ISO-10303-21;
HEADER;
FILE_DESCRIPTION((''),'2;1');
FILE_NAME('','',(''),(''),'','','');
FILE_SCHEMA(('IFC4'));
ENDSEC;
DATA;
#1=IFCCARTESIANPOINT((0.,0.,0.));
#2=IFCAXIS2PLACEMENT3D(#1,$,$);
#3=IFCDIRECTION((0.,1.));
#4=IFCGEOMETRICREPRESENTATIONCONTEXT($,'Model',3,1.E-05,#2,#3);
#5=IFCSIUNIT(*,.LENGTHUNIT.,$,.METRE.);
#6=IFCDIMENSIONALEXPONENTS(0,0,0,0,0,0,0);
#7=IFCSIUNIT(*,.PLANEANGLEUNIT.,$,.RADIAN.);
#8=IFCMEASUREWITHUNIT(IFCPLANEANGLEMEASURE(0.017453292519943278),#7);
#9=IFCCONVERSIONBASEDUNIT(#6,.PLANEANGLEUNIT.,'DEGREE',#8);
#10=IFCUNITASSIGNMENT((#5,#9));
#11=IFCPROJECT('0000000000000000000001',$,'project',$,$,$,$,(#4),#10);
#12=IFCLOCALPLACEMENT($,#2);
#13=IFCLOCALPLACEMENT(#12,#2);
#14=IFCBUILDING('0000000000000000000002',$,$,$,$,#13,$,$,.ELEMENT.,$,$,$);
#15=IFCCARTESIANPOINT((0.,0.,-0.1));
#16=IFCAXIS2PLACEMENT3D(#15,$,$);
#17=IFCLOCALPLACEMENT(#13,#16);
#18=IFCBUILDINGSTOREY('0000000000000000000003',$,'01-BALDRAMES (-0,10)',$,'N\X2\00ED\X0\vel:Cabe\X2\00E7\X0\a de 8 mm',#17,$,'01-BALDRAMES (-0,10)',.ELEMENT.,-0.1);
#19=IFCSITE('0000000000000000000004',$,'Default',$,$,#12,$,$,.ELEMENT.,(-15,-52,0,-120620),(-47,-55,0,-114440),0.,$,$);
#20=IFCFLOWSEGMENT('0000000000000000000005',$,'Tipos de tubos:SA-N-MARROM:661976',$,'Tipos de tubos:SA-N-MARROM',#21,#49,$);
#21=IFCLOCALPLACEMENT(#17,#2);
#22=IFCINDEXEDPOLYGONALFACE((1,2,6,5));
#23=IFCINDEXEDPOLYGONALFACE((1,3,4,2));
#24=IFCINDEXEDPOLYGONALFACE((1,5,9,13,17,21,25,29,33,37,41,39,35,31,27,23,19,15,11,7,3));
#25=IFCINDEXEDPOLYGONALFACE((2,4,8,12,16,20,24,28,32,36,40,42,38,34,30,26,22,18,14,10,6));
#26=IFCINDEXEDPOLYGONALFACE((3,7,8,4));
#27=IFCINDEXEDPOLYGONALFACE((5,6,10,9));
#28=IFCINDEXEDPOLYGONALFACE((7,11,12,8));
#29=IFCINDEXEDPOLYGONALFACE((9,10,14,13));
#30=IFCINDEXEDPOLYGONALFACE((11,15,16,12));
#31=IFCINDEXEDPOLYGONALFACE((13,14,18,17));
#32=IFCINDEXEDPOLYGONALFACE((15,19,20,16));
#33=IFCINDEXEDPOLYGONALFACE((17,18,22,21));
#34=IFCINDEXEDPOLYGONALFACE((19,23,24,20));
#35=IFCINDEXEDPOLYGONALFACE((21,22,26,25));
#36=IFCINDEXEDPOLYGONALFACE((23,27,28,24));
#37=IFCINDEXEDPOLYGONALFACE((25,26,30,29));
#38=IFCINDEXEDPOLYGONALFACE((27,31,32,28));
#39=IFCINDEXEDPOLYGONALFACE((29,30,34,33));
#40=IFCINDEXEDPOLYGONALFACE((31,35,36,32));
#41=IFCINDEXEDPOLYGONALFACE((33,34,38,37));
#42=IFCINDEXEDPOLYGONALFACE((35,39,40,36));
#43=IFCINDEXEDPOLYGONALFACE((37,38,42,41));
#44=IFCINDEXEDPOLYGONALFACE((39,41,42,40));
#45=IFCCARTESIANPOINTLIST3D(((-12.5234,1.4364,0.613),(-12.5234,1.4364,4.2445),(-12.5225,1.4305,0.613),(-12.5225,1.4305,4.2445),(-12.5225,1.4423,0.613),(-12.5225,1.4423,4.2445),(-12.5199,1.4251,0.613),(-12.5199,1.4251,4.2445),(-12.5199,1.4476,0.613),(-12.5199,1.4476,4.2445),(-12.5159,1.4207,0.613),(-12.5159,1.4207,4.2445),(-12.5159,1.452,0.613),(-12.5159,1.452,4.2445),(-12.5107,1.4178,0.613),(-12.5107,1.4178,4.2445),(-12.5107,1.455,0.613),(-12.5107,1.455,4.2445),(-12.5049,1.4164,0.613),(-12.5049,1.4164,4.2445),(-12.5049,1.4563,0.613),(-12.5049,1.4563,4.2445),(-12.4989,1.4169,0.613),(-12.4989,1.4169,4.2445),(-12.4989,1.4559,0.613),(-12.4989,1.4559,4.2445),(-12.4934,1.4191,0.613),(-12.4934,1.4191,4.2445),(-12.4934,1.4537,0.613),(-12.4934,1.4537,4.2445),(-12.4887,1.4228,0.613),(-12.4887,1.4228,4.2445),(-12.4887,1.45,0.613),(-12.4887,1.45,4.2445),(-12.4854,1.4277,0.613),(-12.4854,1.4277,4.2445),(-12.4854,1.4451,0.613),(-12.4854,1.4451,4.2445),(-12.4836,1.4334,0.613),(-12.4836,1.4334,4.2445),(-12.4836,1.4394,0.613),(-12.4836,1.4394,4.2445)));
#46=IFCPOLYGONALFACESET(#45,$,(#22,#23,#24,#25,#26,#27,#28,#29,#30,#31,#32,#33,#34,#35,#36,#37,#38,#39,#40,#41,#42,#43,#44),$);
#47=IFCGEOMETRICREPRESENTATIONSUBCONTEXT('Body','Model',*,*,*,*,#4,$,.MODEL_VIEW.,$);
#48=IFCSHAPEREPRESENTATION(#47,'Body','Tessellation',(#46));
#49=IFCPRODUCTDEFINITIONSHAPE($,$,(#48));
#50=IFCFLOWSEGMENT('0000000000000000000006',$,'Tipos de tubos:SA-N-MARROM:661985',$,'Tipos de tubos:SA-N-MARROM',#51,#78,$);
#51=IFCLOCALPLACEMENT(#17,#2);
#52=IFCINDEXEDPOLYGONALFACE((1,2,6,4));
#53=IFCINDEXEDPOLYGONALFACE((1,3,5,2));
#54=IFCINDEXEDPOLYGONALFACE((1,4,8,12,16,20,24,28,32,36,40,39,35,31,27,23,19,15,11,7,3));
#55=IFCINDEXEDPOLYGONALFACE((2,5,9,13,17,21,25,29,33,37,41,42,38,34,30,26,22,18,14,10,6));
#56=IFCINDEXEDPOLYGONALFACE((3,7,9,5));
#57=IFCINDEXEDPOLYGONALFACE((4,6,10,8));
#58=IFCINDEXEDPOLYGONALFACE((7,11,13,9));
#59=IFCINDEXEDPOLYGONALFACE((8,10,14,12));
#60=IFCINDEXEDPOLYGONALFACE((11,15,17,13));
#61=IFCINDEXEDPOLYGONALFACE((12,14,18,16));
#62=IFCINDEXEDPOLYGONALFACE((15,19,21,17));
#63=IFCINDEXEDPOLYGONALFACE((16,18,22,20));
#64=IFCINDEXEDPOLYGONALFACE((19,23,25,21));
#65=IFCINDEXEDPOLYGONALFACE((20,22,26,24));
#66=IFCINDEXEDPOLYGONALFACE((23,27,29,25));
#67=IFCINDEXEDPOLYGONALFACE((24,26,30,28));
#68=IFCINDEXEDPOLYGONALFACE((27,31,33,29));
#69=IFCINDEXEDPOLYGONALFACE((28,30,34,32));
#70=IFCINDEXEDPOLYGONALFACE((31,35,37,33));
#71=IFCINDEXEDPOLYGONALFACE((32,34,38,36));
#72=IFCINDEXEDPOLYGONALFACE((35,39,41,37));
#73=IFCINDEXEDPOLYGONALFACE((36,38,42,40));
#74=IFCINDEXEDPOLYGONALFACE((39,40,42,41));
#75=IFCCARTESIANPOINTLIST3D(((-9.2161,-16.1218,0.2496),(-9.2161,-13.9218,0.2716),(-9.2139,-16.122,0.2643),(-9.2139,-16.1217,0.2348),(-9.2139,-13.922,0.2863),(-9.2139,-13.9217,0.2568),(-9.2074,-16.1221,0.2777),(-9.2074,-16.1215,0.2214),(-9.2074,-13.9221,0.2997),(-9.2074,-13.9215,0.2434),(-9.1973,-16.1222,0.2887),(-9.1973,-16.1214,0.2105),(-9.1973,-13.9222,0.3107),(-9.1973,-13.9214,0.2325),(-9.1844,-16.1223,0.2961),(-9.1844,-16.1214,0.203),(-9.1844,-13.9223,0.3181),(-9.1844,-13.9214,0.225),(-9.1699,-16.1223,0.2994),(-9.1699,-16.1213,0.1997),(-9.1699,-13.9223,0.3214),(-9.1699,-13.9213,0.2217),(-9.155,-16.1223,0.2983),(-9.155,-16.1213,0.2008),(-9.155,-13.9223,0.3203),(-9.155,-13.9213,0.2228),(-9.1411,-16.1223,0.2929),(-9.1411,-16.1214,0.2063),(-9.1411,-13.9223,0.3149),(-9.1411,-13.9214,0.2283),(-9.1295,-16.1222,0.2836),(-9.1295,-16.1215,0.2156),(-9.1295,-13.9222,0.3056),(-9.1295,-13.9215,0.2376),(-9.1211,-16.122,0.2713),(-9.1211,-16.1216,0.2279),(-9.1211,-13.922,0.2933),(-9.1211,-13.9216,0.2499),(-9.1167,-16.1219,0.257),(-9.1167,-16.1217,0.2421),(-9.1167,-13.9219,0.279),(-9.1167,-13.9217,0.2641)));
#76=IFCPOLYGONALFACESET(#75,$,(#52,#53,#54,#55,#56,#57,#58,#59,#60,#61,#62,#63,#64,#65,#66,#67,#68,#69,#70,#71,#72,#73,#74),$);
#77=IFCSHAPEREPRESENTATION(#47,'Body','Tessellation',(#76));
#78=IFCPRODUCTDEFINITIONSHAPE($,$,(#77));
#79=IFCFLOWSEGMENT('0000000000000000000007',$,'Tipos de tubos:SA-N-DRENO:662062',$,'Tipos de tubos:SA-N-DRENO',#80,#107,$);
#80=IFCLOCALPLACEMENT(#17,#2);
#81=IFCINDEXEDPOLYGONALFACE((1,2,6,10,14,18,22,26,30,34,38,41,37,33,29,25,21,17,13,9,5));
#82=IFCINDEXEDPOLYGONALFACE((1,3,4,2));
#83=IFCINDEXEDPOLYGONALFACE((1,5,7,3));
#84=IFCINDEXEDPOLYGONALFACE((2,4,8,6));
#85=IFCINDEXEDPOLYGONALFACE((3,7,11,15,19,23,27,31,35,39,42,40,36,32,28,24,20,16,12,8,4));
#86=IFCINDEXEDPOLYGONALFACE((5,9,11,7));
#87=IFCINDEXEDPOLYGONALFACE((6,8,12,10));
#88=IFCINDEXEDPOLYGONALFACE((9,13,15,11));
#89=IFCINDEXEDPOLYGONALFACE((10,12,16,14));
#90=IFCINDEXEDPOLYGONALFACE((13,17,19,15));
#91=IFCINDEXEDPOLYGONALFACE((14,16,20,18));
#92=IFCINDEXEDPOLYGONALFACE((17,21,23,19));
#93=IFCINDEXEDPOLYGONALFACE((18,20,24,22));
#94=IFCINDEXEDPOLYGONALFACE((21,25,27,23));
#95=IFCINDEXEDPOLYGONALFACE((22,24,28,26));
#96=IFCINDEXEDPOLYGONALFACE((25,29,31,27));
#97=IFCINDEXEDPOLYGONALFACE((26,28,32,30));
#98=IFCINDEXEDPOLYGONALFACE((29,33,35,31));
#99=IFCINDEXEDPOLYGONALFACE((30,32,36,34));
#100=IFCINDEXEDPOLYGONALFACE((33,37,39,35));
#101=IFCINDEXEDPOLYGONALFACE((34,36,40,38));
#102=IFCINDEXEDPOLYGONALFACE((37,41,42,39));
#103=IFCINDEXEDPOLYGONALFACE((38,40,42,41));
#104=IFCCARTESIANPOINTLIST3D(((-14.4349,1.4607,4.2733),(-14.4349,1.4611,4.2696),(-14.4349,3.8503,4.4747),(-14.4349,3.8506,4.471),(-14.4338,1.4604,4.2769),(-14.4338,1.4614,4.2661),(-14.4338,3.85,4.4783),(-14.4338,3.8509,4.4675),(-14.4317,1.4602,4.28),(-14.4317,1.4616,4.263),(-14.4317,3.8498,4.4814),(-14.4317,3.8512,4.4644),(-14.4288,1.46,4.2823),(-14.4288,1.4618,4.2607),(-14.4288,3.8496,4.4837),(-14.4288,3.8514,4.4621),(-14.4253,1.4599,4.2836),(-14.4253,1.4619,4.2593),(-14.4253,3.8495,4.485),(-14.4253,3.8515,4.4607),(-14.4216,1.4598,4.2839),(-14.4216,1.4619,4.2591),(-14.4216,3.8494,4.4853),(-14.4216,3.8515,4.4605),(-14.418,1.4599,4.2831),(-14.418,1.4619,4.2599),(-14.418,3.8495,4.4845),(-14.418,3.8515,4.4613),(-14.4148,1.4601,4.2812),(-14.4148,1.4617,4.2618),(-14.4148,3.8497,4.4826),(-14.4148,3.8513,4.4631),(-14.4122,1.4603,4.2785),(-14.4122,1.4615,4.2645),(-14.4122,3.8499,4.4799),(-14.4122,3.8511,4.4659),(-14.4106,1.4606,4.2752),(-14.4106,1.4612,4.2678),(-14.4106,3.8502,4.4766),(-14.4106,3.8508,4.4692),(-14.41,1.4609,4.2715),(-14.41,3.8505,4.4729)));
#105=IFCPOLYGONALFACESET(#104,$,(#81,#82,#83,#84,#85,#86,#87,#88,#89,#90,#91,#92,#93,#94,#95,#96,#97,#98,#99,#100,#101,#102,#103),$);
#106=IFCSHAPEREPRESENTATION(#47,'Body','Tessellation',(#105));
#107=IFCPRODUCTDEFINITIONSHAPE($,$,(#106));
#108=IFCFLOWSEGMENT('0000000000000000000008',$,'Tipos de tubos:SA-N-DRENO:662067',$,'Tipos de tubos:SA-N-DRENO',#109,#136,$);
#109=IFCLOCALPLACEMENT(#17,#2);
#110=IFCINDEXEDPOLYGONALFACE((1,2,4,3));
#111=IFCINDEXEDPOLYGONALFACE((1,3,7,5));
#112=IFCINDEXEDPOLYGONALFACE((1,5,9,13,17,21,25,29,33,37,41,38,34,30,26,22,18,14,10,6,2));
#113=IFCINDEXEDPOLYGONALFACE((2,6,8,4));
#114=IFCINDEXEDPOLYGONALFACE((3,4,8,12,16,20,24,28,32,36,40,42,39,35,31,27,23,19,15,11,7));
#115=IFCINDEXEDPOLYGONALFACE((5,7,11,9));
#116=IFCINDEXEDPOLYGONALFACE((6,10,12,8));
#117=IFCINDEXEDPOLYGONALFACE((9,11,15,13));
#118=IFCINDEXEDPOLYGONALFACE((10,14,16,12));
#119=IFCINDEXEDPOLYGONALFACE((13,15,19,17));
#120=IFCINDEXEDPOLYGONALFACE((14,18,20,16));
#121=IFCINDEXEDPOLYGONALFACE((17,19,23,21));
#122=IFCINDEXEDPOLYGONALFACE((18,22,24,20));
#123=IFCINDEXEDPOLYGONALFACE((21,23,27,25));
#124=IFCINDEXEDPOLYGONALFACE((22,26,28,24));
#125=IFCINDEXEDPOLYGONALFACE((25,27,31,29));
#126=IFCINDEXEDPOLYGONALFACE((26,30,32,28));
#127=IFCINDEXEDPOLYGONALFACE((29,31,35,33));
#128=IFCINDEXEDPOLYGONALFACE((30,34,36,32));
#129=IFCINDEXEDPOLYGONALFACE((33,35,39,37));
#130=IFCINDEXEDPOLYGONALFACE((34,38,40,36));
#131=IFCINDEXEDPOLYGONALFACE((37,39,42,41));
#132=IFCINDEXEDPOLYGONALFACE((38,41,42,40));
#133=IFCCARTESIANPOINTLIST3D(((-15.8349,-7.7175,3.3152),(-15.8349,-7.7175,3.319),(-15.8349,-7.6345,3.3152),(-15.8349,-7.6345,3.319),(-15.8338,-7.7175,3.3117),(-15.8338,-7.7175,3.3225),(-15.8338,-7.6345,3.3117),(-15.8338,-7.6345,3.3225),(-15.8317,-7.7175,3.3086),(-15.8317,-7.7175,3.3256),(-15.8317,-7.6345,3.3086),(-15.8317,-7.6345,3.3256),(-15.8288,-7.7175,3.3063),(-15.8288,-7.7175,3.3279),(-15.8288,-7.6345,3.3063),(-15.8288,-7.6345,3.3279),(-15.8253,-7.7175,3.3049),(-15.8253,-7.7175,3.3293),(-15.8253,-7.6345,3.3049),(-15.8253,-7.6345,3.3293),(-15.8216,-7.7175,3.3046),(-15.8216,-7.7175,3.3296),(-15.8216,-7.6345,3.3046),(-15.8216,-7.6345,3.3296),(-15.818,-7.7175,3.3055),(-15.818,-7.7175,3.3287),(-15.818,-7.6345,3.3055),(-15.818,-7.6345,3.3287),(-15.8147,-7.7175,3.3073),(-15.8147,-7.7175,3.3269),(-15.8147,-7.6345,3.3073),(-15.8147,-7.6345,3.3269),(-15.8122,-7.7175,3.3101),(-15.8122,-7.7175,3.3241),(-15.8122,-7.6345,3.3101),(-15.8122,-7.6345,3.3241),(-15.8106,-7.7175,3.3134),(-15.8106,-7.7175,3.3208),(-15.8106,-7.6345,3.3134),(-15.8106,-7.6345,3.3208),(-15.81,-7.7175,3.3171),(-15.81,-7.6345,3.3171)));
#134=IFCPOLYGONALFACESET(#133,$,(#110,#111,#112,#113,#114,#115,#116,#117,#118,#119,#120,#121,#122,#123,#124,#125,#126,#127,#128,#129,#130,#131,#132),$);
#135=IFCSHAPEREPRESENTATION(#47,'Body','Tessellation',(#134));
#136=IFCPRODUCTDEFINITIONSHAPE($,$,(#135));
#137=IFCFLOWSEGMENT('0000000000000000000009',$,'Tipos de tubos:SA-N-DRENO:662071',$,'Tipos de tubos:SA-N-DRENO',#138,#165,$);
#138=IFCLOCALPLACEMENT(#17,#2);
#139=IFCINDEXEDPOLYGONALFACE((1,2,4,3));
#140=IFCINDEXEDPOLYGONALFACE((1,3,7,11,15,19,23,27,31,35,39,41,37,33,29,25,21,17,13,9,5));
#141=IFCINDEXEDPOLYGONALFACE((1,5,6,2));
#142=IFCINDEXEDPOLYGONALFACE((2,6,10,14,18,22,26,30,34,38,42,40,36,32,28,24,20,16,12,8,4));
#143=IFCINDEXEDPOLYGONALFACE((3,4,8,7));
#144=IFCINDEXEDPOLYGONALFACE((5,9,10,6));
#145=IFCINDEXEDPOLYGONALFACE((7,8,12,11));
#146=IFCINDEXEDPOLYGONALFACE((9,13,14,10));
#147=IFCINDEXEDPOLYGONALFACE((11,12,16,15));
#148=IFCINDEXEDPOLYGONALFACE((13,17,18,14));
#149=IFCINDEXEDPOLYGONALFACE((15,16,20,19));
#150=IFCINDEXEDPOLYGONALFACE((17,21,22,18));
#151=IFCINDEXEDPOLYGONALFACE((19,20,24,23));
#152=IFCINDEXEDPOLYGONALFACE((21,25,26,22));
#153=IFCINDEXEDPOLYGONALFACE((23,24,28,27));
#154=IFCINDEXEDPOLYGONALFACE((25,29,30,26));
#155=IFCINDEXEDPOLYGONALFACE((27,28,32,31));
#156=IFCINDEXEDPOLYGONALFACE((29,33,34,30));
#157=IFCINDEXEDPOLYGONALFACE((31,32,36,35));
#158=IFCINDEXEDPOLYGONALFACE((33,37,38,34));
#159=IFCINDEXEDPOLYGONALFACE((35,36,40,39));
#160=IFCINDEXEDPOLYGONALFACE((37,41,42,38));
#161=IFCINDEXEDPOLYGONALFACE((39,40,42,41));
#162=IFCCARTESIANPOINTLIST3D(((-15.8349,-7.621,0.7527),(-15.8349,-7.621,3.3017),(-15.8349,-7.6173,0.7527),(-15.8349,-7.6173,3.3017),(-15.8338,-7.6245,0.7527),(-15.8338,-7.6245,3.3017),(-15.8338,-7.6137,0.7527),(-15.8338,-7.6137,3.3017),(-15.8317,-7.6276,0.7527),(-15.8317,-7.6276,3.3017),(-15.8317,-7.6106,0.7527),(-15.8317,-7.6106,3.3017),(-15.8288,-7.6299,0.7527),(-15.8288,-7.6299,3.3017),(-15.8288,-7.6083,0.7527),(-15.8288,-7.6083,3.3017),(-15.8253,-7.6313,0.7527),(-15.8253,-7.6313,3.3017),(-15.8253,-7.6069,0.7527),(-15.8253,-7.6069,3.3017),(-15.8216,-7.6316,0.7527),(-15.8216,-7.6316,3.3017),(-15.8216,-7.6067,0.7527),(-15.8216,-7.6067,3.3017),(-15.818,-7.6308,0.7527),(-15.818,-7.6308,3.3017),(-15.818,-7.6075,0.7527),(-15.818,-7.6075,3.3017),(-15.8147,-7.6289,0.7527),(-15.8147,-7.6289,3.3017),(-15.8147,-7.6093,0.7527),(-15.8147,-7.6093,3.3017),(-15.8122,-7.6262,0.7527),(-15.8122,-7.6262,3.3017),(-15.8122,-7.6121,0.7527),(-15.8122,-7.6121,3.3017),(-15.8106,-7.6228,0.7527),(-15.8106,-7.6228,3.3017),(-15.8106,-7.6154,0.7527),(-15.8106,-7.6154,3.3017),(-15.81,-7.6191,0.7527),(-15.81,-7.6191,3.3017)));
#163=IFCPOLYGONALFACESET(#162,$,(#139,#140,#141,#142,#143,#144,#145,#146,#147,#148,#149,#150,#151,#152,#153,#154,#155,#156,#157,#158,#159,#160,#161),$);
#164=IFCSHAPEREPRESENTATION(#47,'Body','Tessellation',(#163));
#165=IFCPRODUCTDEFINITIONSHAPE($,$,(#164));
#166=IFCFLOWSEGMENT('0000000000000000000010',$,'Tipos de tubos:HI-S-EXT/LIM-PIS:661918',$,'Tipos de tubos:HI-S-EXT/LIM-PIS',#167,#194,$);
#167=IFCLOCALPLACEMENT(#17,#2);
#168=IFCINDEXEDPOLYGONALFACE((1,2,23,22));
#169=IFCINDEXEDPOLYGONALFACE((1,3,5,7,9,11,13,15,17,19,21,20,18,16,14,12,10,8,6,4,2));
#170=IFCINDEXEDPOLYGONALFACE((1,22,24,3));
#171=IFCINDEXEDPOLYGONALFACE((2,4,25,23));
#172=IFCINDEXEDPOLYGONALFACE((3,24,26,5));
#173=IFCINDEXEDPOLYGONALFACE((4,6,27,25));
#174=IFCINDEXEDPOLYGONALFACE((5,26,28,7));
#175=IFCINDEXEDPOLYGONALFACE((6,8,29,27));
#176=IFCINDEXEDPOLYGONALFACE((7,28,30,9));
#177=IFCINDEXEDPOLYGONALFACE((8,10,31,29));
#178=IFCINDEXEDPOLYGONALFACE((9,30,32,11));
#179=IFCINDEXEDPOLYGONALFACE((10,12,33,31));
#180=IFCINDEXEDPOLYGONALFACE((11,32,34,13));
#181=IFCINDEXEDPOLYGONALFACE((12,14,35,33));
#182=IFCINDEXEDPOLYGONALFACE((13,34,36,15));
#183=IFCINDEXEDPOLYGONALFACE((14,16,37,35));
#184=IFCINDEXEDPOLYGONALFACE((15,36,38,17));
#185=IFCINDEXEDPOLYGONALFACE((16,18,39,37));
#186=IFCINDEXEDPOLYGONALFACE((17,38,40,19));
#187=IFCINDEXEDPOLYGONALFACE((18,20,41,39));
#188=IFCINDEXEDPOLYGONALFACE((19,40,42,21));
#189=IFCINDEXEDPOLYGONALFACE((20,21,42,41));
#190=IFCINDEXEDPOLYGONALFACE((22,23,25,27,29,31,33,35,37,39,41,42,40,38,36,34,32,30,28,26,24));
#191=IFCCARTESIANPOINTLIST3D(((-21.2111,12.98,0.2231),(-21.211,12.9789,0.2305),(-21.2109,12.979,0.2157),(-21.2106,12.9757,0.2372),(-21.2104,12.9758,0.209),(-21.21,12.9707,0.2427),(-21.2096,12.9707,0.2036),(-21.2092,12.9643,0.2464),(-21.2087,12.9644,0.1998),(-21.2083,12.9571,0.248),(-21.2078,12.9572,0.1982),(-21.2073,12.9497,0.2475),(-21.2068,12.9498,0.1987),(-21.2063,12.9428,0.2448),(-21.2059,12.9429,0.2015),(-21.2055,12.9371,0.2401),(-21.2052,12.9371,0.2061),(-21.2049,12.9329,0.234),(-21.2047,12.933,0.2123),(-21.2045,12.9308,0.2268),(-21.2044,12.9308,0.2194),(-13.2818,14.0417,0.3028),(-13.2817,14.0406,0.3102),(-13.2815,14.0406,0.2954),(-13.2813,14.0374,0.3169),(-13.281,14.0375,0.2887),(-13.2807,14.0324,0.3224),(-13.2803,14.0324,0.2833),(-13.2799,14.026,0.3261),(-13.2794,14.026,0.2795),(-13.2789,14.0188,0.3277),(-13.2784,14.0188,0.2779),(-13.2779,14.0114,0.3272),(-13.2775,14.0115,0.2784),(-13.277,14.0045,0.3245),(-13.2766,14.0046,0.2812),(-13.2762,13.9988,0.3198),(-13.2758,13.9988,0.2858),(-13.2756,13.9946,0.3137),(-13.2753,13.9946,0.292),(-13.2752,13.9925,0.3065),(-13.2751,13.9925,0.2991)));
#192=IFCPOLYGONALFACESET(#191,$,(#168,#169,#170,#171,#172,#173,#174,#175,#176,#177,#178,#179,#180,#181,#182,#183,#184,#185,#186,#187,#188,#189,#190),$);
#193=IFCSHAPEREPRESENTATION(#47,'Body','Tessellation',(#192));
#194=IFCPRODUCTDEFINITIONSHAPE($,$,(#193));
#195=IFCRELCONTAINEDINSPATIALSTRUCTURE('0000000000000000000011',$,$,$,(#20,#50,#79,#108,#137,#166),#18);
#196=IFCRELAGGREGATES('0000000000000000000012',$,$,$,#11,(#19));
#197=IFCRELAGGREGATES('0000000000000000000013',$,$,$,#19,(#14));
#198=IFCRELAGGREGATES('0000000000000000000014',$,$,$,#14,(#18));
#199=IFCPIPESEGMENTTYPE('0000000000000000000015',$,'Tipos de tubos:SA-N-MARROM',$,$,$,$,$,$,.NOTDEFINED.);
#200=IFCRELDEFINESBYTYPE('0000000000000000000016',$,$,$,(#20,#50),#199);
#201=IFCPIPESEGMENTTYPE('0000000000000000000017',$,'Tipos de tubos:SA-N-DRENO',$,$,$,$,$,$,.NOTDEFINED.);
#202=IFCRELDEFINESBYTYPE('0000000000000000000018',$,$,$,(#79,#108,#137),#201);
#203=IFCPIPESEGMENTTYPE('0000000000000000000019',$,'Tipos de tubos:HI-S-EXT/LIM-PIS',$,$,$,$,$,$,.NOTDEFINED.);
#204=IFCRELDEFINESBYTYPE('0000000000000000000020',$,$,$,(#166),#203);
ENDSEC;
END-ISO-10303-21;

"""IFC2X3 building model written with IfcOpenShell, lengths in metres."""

from ifc_helpers import new_model, entity, si_unit, converted_unit, direction, frame, frame_2d, origin, origin_2d_with_axis, place, context, subcontext, project, spatial, circle, extrude, type_object, element, save


model = new_model("IFC2X3")

# Units and contexts
model_context = context("Model", 3, precision=1e-05, world=origin(), true_north=direction((0.0, 1.0)))
body_context = subcontext(model_context, "Body", "Model", "MODEL_VIEW")
ifc_project = project(units=[si_unit("LENGTHUNIT", "METRE"), converted_unit("PLANEANGLEUNIT", "DEGREE", entity("IfcPlaneAngleMeasure", 0.017453292519943278), si_unit("PLANEANGLEUNIT", "RADIAN"), dimensions=[0, 0, 0, 0, 0, 0, 0])], contexts=[model_context])

# Site, building, storey
site_placement = place(None, origin())
site = spatial("IfcSite", under=ifc_project, at=site_placement, Name="Default", CompositionType="ELEMENT", RefLatitude=(-15, -52, 0, -120620), RefLongitude=(-47, -55, 0, -114440), RefElevation=0.0)
building_placement = place(site_placement, origin())
building = spatial("IfcBuilding", under=site, at=building_placement, CompositionType="ELEMENT")
storey_placement = place(building_placement, frame((0.0, 0.0, -0.1)))
storey = spatial("IfcBuildingStorey", under=building, at=storey_placement, Name="01-BALDRAMES (-0,10)", ObjectType="Nível:Cabeça de 8 mm", LongName="01-BALDRAMES (-0,10)", CompositionType="ELEMENT", Elevation=-0.1)

# Flow segments
pipe_segment_type_1 = type_object("IfcPipeSegmentType", Name="Tipos de tubos:SA-N-MARROM", PredefinedType="NOTDEFINED")
flow_segment_1_placement = place(storey_placement, origin())
element("IfcFlowSegment", 1, at=flow_segment_1_placement, inside=storey, type_object=pipe_segment_type_1, Name="Tipos de tubos:SA-N-MARROM:661976", ObjectType="Tipos de tubos:SA-N-MARROM", context=body_context, shape_type="SweptSolid", body=[
    extrude(circle(Radius=0.02, at=origin_2d_with_axis()), frame((-12.5034, 1.4364, 0.613), z_axis=(0.0, 0.0, 1.0), x_axis=(-1.0, 0.0, 0.0)), (0.0, 0.0, 1.0), 3.6315),
])
flow_segment_2_placement = place(storey_placement, origin())
element("IfcFlowSegment", 2, at=flow_segment_2_placement, inside=storey, type_object=pipe_segment_type_1, Name="Tipos de tubos:SA-N-MARROM:661985", ObjectType="Tipos de tubos:SA-N-MARROM", context=body_context, shape_type="SweptSolid", body=[
    extrude(circle(Radius=0.05, at=frame_2d((0.0, 0.0), x_axis=(1.0, 0.0))), frame((-9.1661, -16.1218, 0.2496), z_axis=(-0.000001, 0.99995, 0.01), x_axis=(-1.0, -0.000001, 0.0)), (0.0, 0.0, 1.0), 2.2001),
])
pipe_segment_type_2 = type_object("IfcPipeSegmentType", Name="Tipos de tubos:SA-N-DRENO", PredefinedType="NOTDEFINED")
flow_segment_3_placement = place(storey_placement, origin())
element("IfcFlowSegment", 3, at=flow_segment_3_placement, inside=storey, type_object=pipe_segment_type_2, Name="Tipos de tubos:SA-N-DRENO:662062", ObjectType="Tipos de tubos:SA-N-DRENO", context=body_context, shape_type="SweptSolid", body=[
    extrude(circle(Radius=0.0125, at=frame_2d((0.0, 0.0), x_axis=(1.0, 0.0))), frame((-14.4225, 1.4609, 4.2715), z_axis=(-0.000001, 0.996467, 0.083982), x_axis=(1.0, 0.000001, 0.0)), (0.0, 0.0, 1.0), 2.398),
])
flow_segment_4_placement = place(storey_placement, origin())
element("IfcFlowSegment", 4, at=flow_segment_4_placement, inside=storey, type_object=pipe_segment_type_2, Name="Tipos de tubos:SA-N-DRENO:662067", ObjectType="Tipos de tubos:SA-N-DRENO", context=body_context, shape_type="SweptSolid", body=[
    extrude(circle(Radius=0.0125, at=origin_2d_with_axis()), frame((-15.8225, -7.7175, 3.3171), z_axis=(-0.000001, 1.0, 0.0), x_axis=(1.0, 0.000001, 0.0)), (0.0, 0.0, 1.0), 0.083),
])
flow_segment_5_placement = place(storey_placement, origin())
element("IfcFlowSegment", 5, at=flow_segment_5_placement, inside=storey, type_object=pipe_segment_type_2, Name="Tipos de tubos:SA-N-DRENO:662071", ObjectType="Tipos de tubos:SA-N-DRENO", context=body_context, shape_type="SweptSolid", body=[
    extrude(circle(Radius=0.0125, at=origin_2d_with_axis()), frame((-15.8225, -7.6191, 0.7527)), (0.0, 0.0, 1.0), 2.549),
])
pipe_segment_type_3 = type_object("IfcPipeSegmentType", Name="Tipos de tubos:HI-S-EXT/LIM-PIS", PredefinedType="NOTDEFINED")
flow_segment_6_placement = place(storey_placement, origin())
element("IfcFlowSegment", 6, at=flow_segment_6_placement, inside=storey, type_object=pipe_segment_type_3, Name="Tipos de tubos:HI-S-EXT/LIM-PIS:661918", ObjectType="Tipos de tubos:HI-S-EXT/LIM-PIS", context=body_context, shape_type="SweptSolid", body=[
    extrude(circle(Radius=0.025, at=frame_2d((0.0, 0.0), x_axis=(1.0, 0.0))), frame((-21.2078, 12.9553, 0.2231), z_axis=(0.991106, 0.132704, 0.009962), x_axis=(-0.13271, 0.991155, 0.0)), (0.0, 0.0, 1.0), 8.0005),
])

save(model, "model.ifc")
